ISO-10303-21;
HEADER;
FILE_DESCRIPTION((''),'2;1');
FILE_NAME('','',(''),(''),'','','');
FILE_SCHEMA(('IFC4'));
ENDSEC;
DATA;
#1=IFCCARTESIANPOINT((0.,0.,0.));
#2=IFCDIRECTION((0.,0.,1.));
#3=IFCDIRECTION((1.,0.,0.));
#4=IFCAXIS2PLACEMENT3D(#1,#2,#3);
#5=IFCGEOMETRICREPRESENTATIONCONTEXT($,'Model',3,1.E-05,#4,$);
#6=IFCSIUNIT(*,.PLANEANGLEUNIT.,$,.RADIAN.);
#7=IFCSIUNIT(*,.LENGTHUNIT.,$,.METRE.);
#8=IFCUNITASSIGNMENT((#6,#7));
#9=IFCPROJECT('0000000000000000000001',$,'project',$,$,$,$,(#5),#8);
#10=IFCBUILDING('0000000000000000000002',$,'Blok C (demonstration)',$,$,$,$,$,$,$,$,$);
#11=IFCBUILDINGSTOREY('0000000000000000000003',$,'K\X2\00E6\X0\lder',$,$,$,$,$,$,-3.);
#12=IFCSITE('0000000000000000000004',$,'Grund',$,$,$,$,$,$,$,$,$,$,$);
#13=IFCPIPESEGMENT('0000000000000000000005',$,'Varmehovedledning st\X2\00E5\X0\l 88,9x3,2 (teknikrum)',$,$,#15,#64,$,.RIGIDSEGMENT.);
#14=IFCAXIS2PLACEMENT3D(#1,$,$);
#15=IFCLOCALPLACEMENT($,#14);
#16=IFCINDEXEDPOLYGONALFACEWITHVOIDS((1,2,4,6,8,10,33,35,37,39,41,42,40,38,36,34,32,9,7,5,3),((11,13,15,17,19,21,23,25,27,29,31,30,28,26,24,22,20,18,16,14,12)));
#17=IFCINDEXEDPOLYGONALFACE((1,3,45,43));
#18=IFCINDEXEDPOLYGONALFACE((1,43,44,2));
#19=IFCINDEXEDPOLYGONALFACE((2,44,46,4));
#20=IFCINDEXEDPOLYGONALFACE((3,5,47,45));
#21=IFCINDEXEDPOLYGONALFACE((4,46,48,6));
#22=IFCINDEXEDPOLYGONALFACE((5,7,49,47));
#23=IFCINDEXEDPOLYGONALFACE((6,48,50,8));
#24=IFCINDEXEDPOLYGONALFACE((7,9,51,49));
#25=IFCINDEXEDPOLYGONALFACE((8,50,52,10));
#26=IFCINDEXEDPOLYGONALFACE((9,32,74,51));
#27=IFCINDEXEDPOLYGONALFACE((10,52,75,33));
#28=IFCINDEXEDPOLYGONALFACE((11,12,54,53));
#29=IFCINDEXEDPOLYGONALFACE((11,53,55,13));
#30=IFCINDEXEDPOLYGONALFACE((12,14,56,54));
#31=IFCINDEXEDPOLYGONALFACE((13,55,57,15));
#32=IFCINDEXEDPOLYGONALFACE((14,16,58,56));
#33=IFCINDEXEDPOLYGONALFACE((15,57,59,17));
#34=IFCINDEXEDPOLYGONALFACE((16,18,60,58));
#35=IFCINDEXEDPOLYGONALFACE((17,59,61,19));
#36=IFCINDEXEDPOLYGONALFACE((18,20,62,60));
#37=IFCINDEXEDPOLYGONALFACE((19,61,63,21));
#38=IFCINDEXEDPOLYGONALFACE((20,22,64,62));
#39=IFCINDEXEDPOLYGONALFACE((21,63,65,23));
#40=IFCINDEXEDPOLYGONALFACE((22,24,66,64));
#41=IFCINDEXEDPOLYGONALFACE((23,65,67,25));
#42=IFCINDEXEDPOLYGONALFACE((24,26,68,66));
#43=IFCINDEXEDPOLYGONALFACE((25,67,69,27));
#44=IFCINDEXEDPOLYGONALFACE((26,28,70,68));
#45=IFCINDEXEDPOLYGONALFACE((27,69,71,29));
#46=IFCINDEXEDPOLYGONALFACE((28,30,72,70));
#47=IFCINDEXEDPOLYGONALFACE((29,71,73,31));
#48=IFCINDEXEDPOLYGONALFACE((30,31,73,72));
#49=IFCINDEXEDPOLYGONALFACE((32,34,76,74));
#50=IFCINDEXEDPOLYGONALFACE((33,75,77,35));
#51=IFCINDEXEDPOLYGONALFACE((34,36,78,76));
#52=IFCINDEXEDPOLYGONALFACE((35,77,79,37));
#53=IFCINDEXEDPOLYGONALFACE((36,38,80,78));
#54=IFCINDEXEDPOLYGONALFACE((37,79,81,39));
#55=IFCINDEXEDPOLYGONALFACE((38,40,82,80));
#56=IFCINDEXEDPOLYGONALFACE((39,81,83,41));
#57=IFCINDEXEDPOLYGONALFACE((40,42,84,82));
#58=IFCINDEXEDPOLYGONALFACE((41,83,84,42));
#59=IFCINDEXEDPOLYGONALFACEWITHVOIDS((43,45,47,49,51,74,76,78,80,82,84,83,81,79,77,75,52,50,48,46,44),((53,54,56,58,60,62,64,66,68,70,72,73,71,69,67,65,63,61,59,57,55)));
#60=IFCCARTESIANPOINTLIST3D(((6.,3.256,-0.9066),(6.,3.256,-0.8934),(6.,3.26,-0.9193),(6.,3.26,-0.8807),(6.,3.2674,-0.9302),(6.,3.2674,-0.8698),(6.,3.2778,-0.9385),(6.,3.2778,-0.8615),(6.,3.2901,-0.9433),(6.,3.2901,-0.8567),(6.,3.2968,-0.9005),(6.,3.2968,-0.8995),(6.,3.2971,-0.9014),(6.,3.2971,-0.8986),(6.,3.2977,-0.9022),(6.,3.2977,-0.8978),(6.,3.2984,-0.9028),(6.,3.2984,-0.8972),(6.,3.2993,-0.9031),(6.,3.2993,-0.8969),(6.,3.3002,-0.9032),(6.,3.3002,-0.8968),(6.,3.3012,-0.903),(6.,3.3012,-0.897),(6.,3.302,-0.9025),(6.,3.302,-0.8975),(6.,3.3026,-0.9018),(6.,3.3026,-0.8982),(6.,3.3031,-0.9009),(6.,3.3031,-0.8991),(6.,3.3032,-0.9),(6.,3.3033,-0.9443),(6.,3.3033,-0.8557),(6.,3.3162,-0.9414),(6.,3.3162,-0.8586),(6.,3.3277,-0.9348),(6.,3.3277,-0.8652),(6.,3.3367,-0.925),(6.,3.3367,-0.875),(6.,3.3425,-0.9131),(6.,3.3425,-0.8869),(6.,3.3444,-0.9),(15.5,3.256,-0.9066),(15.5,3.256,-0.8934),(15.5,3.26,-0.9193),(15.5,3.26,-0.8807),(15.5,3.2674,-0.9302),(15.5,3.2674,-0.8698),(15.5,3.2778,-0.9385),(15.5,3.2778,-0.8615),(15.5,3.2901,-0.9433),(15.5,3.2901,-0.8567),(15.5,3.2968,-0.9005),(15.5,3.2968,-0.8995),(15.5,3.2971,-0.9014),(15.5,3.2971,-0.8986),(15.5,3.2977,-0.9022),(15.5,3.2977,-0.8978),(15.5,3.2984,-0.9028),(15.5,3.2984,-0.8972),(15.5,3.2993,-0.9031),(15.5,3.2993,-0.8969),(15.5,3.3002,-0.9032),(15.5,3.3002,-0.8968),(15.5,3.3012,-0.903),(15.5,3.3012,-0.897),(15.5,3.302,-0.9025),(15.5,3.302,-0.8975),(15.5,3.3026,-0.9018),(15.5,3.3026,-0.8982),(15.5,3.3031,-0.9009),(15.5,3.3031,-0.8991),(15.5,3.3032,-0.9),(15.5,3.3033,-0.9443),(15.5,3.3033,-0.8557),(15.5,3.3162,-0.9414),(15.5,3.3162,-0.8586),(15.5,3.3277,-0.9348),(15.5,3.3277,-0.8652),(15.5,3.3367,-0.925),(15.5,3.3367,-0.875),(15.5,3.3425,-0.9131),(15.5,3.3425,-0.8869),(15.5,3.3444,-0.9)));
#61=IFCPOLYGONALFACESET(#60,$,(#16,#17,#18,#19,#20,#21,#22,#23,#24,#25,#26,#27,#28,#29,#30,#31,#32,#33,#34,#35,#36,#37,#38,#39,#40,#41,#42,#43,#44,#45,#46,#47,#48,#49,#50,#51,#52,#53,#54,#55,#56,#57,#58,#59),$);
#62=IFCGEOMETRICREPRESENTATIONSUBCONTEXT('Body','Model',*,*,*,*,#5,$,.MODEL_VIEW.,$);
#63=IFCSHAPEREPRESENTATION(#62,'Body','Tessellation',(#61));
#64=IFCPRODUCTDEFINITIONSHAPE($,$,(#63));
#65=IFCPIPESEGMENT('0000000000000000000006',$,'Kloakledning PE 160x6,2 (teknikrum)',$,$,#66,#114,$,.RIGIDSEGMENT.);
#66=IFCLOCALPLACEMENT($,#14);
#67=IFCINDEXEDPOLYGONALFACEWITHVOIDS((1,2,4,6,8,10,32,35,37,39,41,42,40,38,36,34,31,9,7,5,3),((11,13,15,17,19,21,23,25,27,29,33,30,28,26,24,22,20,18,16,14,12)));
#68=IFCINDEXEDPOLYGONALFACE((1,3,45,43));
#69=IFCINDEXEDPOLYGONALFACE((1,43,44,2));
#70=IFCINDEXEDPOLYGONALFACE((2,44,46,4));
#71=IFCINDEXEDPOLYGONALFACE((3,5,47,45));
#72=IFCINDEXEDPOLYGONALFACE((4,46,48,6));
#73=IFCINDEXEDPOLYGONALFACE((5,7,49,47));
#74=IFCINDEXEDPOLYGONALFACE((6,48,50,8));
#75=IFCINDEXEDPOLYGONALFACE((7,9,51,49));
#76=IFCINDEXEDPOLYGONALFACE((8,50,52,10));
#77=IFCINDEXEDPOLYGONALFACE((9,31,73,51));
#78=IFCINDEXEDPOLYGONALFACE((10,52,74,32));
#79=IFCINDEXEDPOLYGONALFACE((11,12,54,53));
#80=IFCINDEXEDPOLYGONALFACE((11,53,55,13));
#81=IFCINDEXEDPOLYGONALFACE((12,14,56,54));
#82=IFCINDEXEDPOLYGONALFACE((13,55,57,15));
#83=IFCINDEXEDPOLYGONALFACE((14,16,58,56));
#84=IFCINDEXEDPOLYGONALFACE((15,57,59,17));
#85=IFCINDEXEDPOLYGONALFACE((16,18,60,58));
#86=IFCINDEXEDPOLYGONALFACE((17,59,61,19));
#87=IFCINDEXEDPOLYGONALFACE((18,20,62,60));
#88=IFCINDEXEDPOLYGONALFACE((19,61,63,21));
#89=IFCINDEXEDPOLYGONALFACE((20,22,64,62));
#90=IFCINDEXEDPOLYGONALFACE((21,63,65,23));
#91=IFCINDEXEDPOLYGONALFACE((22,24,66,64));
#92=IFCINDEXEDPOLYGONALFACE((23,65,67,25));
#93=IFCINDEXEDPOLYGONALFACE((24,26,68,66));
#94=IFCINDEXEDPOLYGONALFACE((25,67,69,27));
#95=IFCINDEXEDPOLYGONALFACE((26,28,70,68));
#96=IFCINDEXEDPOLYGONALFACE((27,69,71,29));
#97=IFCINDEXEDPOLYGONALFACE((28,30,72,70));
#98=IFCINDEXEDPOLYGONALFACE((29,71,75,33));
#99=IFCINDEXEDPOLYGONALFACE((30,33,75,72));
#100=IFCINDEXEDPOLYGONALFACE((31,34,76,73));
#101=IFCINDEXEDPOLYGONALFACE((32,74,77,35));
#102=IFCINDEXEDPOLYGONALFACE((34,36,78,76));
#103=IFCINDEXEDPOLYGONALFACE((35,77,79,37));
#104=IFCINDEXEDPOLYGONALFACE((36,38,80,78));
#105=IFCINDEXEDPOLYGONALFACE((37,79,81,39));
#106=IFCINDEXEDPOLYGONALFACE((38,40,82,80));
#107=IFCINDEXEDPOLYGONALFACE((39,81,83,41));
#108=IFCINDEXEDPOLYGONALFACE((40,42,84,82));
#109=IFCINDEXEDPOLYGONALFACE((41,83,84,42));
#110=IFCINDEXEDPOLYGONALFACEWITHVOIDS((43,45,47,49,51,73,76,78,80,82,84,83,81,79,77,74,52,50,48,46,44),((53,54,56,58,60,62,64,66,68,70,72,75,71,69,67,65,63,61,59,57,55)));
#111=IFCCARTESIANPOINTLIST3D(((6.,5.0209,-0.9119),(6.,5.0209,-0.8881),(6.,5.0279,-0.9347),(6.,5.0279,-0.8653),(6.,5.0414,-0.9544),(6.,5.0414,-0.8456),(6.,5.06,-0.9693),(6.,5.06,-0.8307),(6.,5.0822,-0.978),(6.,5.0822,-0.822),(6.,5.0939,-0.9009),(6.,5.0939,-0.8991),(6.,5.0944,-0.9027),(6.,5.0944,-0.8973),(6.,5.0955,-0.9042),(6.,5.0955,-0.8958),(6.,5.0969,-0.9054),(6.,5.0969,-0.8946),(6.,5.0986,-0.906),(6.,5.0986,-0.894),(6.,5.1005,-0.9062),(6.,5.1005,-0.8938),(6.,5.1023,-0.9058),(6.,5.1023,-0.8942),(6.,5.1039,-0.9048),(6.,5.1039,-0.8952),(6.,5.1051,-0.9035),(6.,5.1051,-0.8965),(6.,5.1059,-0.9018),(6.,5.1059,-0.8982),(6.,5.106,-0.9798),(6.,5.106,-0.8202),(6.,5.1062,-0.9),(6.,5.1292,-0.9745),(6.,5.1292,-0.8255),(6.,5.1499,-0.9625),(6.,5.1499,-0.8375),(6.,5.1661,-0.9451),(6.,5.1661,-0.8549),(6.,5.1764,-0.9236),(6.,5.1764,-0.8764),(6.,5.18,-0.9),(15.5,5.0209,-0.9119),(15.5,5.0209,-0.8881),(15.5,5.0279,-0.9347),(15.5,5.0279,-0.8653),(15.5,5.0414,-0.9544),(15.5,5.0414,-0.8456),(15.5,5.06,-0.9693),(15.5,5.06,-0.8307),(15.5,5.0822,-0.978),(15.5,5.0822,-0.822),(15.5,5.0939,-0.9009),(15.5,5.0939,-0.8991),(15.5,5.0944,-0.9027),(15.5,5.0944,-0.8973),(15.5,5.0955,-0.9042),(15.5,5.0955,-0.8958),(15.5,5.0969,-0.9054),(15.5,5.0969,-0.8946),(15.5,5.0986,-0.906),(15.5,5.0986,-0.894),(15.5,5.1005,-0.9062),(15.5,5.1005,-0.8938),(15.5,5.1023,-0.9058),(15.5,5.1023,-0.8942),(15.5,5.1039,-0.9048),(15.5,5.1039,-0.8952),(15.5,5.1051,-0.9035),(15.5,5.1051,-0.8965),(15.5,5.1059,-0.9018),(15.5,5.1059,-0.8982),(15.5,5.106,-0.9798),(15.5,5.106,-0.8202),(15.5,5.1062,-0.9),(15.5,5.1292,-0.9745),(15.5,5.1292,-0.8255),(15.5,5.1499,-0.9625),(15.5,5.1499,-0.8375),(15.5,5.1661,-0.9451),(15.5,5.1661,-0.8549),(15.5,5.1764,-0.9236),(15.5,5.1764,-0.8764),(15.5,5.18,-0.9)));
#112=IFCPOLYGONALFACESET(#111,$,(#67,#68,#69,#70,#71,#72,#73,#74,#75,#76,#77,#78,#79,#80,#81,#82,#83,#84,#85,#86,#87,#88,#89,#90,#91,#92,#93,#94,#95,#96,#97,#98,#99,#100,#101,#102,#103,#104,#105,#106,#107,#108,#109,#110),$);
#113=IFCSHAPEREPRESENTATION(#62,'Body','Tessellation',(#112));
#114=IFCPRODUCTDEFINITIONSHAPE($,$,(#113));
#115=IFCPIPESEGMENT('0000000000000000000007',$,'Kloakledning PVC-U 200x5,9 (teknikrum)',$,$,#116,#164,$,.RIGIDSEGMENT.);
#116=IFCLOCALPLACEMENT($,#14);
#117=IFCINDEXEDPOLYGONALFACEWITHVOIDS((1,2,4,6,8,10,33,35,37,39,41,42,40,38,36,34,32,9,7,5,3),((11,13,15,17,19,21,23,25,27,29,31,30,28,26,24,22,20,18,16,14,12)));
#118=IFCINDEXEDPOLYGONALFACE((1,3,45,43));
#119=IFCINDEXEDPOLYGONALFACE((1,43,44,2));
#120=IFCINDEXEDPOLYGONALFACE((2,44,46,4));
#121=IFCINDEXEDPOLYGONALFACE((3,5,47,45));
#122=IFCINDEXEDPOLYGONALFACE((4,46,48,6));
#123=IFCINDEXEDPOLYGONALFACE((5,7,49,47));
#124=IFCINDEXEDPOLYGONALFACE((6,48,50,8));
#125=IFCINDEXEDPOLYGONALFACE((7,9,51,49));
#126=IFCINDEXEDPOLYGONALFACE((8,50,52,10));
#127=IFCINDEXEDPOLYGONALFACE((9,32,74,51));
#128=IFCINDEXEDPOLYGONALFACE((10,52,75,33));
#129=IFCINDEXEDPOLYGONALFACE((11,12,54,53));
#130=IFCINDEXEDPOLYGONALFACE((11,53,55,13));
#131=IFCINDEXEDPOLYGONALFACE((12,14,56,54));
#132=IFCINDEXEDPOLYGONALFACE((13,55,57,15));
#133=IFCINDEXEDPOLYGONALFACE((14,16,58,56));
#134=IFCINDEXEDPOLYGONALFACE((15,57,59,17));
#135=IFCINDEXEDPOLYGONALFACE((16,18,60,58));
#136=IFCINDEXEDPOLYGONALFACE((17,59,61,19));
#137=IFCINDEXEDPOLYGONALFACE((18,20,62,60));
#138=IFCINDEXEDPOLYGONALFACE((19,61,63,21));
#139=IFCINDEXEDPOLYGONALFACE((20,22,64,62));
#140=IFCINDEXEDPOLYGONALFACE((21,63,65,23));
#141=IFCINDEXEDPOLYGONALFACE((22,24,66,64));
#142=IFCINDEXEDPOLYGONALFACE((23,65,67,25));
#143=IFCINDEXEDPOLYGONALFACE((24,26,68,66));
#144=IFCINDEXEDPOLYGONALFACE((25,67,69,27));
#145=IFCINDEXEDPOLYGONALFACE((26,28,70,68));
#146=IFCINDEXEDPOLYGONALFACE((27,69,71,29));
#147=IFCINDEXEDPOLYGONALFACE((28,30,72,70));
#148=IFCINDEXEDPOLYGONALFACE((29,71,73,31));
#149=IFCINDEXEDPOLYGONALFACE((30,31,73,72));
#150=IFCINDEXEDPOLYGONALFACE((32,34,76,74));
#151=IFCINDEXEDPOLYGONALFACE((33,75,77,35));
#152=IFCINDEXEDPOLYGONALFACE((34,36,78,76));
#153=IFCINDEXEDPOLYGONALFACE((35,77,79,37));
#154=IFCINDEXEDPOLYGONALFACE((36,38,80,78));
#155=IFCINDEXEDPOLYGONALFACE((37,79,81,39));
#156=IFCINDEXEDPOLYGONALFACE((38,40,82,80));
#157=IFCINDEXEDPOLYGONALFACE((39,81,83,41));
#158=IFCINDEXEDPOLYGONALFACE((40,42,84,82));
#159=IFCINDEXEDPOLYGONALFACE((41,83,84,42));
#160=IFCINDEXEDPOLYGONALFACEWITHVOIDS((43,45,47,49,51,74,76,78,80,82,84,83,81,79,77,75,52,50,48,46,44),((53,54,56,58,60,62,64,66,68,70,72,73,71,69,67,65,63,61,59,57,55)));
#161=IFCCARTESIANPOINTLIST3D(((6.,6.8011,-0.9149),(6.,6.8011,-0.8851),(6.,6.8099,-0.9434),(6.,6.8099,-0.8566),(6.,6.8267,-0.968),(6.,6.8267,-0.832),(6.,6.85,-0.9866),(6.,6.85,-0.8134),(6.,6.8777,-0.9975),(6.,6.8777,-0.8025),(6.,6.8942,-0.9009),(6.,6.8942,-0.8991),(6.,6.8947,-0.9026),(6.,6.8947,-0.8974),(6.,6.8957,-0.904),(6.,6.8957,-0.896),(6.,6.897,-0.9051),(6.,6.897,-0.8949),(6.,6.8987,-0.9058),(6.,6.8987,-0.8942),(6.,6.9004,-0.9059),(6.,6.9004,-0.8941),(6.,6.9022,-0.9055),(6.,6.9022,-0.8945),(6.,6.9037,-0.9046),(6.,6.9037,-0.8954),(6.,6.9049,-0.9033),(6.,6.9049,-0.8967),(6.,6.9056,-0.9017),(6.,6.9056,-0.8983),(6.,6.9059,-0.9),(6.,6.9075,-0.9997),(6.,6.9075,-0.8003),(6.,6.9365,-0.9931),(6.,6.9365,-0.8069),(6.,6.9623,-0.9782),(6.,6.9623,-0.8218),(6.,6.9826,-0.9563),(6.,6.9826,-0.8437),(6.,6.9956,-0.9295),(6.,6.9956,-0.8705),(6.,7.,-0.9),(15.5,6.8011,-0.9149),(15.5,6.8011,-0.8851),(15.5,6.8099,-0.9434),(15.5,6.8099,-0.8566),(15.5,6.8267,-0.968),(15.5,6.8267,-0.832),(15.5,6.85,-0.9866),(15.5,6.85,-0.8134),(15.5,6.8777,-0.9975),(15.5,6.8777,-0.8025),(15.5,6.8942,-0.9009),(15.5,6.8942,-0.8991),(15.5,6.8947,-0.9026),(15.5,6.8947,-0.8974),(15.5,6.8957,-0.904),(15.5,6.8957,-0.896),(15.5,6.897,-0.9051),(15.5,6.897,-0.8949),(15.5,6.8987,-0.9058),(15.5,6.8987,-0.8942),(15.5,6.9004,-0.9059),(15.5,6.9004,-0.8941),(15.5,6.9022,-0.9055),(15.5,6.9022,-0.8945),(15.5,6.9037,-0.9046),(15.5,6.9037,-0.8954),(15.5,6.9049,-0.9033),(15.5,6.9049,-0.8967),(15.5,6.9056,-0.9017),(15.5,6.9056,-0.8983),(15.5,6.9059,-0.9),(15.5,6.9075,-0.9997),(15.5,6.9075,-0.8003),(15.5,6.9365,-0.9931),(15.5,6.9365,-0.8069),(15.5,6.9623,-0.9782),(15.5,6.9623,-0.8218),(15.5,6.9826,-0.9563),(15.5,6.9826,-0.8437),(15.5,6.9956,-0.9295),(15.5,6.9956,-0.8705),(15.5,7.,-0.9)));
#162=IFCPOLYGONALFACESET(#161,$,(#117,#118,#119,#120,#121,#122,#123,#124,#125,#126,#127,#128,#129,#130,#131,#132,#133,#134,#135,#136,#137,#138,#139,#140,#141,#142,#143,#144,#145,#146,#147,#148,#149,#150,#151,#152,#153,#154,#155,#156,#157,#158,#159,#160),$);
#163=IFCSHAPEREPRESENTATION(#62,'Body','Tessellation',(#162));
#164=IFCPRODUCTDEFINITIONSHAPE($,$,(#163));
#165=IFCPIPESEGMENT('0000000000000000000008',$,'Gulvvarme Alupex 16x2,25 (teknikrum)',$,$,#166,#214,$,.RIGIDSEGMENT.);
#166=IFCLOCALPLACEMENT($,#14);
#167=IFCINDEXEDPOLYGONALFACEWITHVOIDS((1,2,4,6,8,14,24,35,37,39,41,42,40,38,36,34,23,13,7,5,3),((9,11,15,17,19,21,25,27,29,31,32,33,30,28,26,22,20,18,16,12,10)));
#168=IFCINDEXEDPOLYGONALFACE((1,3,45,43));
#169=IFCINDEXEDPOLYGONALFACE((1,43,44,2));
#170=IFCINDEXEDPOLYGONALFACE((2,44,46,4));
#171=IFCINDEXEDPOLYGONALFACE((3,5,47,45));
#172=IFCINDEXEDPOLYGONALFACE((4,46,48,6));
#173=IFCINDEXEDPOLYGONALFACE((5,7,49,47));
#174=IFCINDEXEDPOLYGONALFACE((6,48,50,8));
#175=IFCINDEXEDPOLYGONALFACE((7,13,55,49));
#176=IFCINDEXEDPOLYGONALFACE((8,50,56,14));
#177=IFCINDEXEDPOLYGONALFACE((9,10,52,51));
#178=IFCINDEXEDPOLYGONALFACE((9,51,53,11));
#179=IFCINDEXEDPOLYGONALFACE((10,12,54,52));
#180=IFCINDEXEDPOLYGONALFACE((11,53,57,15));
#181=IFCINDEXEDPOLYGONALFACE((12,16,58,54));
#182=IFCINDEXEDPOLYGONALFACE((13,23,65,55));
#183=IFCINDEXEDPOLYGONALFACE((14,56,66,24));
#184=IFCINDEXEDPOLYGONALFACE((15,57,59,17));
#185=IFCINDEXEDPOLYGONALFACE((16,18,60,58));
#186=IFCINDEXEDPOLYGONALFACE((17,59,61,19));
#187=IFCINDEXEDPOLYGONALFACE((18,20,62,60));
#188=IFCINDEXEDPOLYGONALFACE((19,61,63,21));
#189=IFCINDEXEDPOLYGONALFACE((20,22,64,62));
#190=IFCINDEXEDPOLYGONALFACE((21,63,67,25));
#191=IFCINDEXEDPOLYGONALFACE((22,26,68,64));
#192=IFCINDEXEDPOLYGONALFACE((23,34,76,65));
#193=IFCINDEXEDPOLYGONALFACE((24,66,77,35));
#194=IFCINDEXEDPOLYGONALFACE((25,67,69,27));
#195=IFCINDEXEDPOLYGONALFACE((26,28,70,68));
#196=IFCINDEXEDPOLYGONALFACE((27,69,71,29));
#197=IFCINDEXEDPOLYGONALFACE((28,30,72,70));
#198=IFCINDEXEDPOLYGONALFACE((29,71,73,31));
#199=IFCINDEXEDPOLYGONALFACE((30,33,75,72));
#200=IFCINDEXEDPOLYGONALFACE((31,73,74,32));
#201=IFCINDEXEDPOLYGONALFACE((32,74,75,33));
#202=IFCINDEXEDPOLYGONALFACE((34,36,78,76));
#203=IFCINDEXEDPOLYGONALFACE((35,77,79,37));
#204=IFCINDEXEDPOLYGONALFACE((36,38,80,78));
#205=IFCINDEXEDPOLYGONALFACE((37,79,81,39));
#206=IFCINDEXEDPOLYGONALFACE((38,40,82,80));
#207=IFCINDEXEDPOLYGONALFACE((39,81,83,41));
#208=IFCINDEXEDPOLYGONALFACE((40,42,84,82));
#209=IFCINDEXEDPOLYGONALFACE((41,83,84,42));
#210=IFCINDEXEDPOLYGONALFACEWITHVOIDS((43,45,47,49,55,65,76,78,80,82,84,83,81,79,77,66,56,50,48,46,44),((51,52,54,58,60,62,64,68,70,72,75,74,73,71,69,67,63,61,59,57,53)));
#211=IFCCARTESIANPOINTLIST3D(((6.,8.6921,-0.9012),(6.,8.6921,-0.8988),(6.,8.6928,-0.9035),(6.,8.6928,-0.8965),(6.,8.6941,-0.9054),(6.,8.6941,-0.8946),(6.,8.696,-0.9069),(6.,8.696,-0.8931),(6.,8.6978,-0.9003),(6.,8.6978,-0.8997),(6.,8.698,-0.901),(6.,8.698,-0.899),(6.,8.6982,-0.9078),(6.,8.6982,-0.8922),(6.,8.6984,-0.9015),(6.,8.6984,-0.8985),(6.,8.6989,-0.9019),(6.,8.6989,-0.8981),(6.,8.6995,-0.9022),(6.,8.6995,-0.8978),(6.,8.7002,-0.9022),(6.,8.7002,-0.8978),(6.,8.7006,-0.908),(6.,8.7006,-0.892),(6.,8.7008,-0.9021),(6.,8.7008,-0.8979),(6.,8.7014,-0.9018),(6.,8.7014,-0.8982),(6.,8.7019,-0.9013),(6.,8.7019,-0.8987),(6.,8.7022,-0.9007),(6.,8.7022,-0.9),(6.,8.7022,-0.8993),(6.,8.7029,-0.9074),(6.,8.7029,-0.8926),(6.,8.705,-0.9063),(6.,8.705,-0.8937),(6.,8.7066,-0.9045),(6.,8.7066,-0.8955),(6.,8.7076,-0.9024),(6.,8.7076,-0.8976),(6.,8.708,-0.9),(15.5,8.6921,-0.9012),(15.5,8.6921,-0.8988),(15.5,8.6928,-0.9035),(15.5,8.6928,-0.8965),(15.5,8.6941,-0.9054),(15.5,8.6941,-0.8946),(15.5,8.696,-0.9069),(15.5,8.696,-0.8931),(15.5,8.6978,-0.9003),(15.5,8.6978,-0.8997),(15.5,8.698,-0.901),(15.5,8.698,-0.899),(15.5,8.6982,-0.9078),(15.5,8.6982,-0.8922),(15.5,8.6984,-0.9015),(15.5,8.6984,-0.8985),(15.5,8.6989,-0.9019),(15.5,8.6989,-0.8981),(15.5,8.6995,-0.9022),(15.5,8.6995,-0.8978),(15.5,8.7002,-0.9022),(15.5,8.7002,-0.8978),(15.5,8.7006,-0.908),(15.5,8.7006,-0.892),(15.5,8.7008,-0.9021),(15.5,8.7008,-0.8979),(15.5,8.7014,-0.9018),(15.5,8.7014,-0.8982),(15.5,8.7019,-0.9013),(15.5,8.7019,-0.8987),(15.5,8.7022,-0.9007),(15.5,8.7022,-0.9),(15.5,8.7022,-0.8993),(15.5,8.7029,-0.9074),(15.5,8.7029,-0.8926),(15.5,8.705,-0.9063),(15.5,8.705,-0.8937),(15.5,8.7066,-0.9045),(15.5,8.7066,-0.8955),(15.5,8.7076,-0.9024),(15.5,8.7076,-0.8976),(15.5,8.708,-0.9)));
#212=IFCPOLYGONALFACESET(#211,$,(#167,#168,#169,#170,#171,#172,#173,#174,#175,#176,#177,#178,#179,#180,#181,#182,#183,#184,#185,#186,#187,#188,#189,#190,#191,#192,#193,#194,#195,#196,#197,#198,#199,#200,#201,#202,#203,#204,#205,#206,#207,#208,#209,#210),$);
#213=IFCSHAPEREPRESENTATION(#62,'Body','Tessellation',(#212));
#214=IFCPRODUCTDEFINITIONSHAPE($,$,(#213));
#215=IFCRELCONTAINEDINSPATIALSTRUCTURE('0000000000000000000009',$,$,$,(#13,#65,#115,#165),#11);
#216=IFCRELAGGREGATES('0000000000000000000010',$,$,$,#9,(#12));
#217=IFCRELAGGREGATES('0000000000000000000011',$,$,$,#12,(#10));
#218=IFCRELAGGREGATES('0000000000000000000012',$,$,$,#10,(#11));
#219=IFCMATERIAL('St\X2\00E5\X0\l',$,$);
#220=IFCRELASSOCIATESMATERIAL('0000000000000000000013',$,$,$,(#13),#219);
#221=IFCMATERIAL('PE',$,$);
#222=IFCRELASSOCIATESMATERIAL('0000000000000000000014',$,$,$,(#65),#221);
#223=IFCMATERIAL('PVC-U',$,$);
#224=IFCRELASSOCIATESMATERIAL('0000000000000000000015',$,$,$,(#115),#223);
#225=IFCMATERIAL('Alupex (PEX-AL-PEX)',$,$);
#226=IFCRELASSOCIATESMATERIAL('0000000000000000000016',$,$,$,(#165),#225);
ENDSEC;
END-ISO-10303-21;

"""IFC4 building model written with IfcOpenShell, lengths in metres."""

from ifc_helpers import new_model, si_unit, frame, origin_with_axes, place, context, subcontext, project, spatial, hollow_circle, extrude, material, element, save


model = new_model("IFC4")

# Units and contexts
model_context = context("Model", 3, precision=1e-05, world=origin_with_axes())
body_context = subcontext(model_context, "Body", "Model", "MODEL_VIEW")
ifc_project = project(units=[si_unit("PLANEANGLEUNIT", "RADIAN"), si_unit("LENGTHUNIT", "METRE")], contexts=[model_context])

# Site, building, storey
site = spatial("IfcSite", under=ifc_project, Name="Grund")
building = spatial("IfcBuilding", under=site, Name="Blok C (demonstration)")
storey = spatial("IfcBuildingStorey", under=building, Name="Kælder", Elevation=-3.0)

# Pipe segments
ifc_material_1 = material(Name="PVC-U")
ifc_material_2 = material(Name="Stål")
pipe_segment_1_placement = place(None, origin_with_axes())
element("IfcPipeSegment", 1, at=pipe_segment_1_placement, inside=storey, material=ifc_material_2, Name="Varmehovedledning stål 88,9x3,2 (teknikrum)", PredefinedType="RIGIDSEGMENT", context=body_context, shape_type="SweptSolid", body=[
    extrude(hollow_circle(Radius=0.0445, WallThickness=0.0413), frame((6.0, 3.3, -0.9), z_axis=(1.0, 0.0, 0.0), x_axis=(0.0, 1.0, 0.0)), (0.0, 0.0, 1.0), 9.5),
])
ifc_material_3 = material(Name="PE")
pipe_segment_2_placement = place(None, origin_with_axes())
element("IfcPipeSegment", 2, at=pipe_segment_2_placement, inside=storey, material=ifc_material_3, Name="Kloakledning PE 160x6,2 (teknikrum)", PredefinedType="RIGIDSEGMENT", context=body_context, shape_type="SweptSolid", body=[
    extrude(hollow_circle(Radius=0.08, WallThickness=0.0738), frame((6.0, 5.1, -0.9), z_axis=(1.0, 0.0, 0.0), x_axis=(0.0, 1.0, 0.0)), (0.0, 0.0, 1.0), 9.5),
])
pipe_segment_3_placement = place(None, origin_with_axes())
element("IfcPipeSegment", 3, at=pipe_segment_3_placement, inside=storey, material=ifc_material_1, Name="Kloakledning PVC-U 200x5,9 (teknikrum)", PredefinedType="RIGIDSEGMENT", context=body_context, shape_type="SweptSolid", body=[
    extrude(hollow_circle(Radius=0.1, WallThickness=0.0941), frame((6.0, 6.9, -0.9), z_axis=(1.0, 0.0, 0.0), x_axis=(0.0, 1.0, 0.0)), (0.0, 0.0, 1.0), 9.5),
])
ifc_material_4 = material(Name="Alupex (PEX-AL-PEX)")
pipe_segment_4_placement = place(None, origin_with_axes())
element("IfcPipeSegment", 4, at=pipe_segment_4_placement, inside=storey, material=ifc_material_4, Name="Gulvvarme Alupex 16x2,25 (teknikrum)", PredefinedType="RIGIDSEGMENT", context=body_context, shape_type="SweptSolid", body=[
    extrude(hollow_circle(Radius=0.008, WallThickness=0.0057), frame((6.0, 8.7, -0.9), z_axis=(1.0, 0.0, 0.0), x_axis=(0.0, 1.0, 0.0)), (0.0, 0.0, 1.0), 9.5),
])

save(model, "model.ifc")
